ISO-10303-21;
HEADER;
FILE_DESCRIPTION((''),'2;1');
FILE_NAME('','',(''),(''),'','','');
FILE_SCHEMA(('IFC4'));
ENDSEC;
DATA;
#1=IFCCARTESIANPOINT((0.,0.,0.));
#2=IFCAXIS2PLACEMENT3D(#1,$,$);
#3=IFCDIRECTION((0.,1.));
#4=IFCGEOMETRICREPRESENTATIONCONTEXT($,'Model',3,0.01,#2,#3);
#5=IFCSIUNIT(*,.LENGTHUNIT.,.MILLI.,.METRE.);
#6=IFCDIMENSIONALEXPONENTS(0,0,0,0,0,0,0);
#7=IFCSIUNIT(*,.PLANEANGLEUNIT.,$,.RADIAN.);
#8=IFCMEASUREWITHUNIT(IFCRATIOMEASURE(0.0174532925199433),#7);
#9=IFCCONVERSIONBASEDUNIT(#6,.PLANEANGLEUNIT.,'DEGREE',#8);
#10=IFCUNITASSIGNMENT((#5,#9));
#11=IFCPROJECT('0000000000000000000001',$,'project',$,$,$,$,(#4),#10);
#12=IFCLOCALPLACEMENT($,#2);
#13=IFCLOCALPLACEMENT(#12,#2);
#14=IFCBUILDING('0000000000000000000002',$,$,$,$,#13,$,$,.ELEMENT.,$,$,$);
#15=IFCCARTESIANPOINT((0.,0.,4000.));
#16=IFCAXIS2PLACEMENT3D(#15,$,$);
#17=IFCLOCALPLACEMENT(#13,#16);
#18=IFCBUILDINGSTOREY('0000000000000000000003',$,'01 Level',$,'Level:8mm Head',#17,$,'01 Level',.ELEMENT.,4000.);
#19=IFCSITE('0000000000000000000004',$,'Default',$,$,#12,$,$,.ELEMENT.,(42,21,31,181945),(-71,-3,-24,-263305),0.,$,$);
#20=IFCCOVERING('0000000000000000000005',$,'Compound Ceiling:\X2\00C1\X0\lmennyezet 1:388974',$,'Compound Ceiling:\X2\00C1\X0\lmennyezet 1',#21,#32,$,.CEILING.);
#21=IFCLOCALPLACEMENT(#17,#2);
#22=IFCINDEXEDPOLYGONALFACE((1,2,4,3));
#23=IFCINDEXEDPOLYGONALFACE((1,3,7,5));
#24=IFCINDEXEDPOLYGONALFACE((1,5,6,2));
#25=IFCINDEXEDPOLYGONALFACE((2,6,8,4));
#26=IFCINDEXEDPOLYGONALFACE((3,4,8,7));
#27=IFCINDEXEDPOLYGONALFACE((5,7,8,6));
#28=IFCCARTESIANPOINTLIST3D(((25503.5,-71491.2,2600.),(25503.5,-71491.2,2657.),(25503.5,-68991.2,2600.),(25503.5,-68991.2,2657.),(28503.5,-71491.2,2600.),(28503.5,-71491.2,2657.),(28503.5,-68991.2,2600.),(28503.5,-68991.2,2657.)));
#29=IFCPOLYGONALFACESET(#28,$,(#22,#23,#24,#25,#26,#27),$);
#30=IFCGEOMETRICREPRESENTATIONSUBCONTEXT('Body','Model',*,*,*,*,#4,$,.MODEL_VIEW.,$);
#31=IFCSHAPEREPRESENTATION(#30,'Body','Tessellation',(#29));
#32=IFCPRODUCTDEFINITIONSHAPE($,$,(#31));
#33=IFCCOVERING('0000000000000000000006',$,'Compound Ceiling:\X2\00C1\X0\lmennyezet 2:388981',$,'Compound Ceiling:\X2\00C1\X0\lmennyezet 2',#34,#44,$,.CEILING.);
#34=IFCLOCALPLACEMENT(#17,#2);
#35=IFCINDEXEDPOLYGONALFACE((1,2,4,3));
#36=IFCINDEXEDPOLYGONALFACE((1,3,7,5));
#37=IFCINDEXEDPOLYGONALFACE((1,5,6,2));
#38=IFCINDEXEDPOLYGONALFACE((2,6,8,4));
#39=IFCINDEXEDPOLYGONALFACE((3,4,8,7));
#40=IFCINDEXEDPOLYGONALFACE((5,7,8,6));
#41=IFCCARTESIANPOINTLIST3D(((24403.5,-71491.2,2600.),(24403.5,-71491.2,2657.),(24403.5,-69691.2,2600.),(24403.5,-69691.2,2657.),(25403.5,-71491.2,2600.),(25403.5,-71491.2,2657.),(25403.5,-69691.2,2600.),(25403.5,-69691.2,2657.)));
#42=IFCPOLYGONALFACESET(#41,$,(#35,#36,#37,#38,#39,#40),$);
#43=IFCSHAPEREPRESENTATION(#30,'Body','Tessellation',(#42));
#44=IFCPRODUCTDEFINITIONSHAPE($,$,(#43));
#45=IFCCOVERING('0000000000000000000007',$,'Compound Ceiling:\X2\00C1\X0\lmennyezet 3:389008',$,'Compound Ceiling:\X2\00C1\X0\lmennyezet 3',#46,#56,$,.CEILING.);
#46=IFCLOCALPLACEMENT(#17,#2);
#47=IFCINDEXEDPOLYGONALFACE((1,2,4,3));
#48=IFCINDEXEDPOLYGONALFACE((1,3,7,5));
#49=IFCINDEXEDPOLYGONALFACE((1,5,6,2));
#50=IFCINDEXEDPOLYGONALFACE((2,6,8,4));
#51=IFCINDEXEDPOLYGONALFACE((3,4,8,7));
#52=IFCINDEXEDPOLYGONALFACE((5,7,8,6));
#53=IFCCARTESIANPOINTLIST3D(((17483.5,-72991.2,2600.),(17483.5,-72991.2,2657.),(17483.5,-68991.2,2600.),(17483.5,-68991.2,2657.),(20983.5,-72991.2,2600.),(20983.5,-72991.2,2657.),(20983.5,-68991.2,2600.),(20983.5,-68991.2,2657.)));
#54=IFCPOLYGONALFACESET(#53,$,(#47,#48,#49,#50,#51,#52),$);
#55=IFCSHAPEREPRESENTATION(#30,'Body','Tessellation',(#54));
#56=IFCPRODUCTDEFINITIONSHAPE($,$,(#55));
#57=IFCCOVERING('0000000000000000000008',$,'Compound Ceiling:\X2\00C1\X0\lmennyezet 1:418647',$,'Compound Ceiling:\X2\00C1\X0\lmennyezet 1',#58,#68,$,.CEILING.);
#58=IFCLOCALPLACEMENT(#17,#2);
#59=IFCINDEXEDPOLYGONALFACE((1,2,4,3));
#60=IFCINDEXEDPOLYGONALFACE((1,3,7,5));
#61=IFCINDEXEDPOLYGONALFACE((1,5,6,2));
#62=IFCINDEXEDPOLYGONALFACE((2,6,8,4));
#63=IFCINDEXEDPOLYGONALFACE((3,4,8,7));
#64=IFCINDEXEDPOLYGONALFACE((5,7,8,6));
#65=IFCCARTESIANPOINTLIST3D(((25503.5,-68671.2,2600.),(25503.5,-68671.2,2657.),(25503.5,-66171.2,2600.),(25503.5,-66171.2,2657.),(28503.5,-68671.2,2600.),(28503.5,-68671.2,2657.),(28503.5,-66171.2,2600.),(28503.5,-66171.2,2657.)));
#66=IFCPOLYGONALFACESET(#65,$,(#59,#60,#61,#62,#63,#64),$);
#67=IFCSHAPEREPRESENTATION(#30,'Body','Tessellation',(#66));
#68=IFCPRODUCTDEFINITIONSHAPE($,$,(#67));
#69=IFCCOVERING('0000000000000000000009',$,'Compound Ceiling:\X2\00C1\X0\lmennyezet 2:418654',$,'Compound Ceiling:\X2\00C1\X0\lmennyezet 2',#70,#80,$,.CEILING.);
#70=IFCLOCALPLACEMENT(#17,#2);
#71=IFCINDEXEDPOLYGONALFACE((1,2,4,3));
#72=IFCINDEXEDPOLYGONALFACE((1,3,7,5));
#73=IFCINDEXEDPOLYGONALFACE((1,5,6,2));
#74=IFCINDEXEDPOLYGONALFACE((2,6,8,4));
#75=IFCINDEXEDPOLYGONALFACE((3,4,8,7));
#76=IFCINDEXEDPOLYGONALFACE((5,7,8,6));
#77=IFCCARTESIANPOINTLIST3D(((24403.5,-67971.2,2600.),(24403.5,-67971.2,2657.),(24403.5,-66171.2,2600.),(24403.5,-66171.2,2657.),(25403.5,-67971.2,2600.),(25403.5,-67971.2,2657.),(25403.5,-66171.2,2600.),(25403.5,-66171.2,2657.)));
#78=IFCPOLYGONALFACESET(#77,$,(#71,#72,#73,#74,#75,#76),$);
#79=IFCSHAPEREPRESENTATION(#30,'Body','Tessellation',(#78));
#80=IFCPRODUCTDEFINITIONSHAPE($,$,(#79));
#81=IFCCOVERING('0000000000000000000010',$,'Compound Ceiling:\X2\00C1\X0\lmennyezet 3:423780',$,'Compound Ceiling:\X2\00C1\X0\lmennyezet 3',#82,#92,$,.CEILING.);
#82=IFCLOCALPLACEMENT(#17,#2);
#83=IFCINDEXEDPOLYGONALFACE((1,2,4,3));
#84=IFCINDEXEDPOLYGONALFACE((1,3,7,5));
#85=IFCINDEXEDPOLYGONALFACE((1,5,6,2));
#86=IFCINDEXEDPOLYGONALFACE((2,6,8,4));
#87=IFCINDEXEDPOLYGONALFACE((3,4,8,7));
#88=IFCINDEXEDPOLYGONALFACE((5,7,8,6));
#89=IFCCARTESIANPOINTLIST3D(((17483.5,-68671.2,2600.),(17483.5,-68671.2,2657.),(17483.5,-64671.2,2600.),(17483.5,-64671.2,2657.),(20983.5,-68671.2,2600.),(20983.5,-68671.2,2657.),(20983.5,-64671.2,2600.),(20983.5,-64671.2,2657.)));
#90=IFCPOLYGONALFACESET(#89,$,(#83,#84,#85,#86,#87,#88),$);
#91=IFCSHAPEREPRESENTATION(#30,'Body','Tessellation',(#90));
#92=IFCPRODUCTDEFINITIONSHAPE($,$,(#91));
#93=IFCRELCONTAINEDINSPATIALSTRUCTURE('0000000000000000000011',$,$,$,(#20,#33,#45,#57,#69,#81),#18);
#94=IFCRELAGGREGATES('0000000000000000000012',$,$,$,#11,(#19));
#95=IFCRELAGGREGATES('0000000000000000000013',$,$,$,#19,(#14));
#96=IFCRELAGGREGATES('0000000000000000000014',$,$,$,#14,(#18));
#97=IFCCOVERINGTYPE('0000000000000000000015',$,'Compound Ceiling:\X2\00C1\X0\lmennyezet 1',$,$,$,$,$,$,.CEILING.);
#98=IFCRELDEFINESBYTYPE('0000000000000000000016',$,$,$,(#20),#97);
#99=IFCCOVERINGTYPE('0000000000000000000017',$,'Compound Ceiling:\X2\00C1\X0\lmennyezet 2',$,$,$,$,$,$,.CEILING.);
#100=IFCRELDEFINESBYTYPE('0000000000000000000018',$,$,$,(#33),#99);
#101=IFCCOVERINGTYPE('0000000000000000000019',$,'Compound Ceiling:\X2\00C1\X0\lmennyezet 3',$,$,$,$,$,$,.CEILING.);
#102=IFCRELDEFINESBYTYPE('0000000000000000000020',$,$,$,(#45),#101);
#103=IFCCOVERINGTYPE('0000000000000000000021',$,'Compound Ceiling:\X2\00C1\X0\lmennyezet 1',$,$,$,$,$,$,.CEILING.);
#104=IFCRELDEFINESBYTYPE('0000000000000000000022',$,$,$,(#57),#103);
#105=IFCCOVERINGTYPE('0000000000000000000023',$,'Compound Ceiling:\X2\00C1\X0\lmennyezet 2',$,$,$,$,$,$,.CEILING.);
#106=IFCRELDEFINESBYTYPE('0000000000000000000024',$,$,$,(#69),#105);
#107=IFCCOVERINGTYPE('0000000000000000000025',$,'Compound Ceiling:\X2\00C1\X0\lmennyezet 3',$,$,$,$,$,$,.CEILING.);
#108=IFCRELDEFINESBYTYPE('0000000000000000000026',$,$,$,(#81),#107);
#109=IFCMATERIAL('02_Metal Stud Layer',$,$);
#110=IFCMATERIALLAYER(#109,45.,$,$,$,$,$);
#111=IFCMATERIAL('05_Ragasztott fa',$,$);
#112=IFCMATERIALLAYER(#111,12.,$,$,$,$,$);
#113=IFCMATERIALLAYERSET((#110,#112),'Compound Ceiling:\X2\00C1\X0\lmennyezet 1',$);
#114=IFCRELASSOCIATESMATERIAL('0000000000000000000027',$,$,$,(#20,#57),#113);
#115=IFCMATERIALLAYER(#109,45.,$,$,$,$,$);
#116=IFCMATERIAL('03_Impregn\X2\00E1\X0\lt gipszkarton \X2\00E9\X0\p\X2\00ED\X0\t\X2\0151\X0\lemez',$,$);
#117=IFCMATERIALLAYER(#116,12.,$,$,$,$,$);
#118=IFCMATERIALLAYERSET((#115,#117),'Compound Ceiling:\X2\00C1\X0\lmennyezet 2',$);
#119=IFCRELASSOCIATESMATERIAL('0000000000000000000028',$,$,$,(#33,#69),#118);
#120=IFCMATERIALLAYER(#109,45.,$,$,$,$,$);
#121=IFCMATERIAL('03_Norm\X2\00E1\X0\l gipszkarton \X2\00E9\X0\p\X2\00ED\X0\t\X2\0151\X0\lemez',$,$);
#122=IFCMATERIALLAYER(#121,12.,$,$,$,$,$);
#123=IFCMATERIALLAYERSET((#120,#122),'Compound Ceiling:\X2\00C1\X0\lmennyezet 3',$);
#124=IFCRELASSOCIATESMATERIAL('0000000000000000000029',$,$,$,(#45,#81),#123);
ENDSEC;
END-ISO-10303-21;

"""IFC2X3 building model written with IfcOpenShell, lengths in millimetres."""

from ifc_helpers import new_model, entity, si_unit, converted_unit, direction, frame, frame_2d, origin, origin_2d_with_axis, place, context, subcontext, project, spatial, rectangle, extrude, material, layer, layer_set, layer_usage, type_object, element, save


model = new_model("IFC2X3")

# Units and contexts
model_context = context("Model", 3, precision=0.01, world=origin(), true_north=direction((0.0, 1.0)))
body_context = subcontext(model_context, "Body", "Model", "MODEL_VIEW")
ifc_project = project(units=[si_unit("LENGTHUNIT", "METRE", prefix="MILLI"), converted_unit("PLANEANGLEUNIT", "DEGREE", entity("IfcRatioMeasure", 0.0174532925199433), si_unit("PLANEANGLEUNIT", "RADIAN"), dimensions=[0, 0, 0, 0, 0, 0, 0])], contexts=[model_context])

# Site, building, storey
site_placement = place(None, origin())
site = spatial("IfcSite", under=ifc_project, at=site_placement, Name="Default", CompositionType="ELEMENT", RefLatitude=(42, 21, 31, 181945), RefLongitude=(-71, -3, -24, -263305), RefElevation=0.0)
building_placement = place(site_placement, origin())
building = spatial("IfcBuilding", under=site, at=building_placement, CompositionType="ELEMENT")
storey_placement = place(building_placement, frame((0.0, 0.0, 4000.0)))
storey = spatial("IfcBuildingStorey", under=building, at=storey_placement, Name="01 Level", ObjectType="Level:8mm Head", LongName="01 Level", CompositionType="ELEMENT", Elevation=4000.0)

# Coverings
ifc_material_1 = material(Name="02_Metal Stud Layer")
ifc_layer_1 = layer(ifc_material_1, 45.0)
ifc_material_2 = material(Name="05_Ragasztott fa")
ifc_layer_2 = layer(ifc_material_2, 12.0)
ifc_layer_set_1 = layer_set([ifc_layer_1, ifc_layer_2], Name="Compound Ceiling:Álmennyezet 1")
ifc_layer_usage_1 = layer_usage(ifc_layer_set_1, "AXIS3", "POSITIVE", 0.0)
covering_type_1 = type_object("IfcCoveringType", Name="Compound Ceiling:Álmennyezet 1", PredefinedType="CEILING")
covering_1_placement = place(storey_placement, frame((25503.5, -71491.2, 2600.0)))
element("IfcCovering", 1, at=covering_1_placement, inside=storey, type_object=covering_type_1, material=ifc_layer_usage_1, Name="Compound Ceiling:Álmennyezet 1:388974", ObjectType="Compound Ceiling:Álmennyezet 1", PredefinedType="CEILING", context=body_context, shape_type="SweptSolid", body=[
    extrude(rectangle(XDim=3000.0, YDim=2500.0, at=frame_2d((0.0, 0.0), x_axis=(1.0, 0.0))), frame((1500.0, 1250.0, 0.0), z_axis=(0.0, 0.0, 1.0), x_axis=(-1.0, 0.0, 0.0)), (0.0, 0.0, 1.0), 57.0),
])
ifc_layer_3 = layer(ifc_material_1, 45.0)
ifc_material_3 = material(Name="03_Impregnált gipszkarton építőlemez")
ifc_layer_4 = layer(ifc_material_3, 12.0)
ifc_layer_set_2 = layer_set([ifc_layer_3, ifc_layer_4], Name="Compound Ceiling:Álmennyezet 2")
ifc_layer_usage_2 = layer_usage(ifc_layer_set_2, "AXIS3", "POSITIVE", 0.0)
covering_type_2 = type_object("IfcCoveringType", Name="Compound Ceiling:Álmennyezet 2", PredefinedType="CEILING")
covering_2_placement = place(storey_placement, frame((24403.5, -71491.2, 2600.0)))
element("IfcCovering", 2, at=covering_2_placement, inside=storey, type_object=covering_type_2, material=ifc_layer_usage_2, Name="Compound Ceiling:Álmennyezet 2:388981", ObjectType="Compound Ceiling:Álmennyezet 2", PredefinedType="CEILING", context=body_context, shape_type="SweptSolid", body=[
    extrude(rectangle(XDim=1000.0, YDim=1800.0, at=frame_2d((0.0, 0.0), x_axis=(1.0, 0.0))), frame((500.0, 900.0, 0.0), z_axis=(0.0, 0.0, 1.0), x_axis=(-1.0, 0.0, 0.0)), (0.0, 0.0, 1.0), 57.0),
])
ifc_layer_5 = layer(ifc_material_1, 45.0)
ifc_material_4 = material(Name="03_Normál gipszkarton építőlemez")
ifc_layer_6 = layer(ifc_material_4, 12.0)
ifc_layer_set_3 = layer_set([ifc_layer_5, ifc_layer_6], Name="Compound Ceiling:Álmennyezet 3")
ifc_layer_usage_3 = layer_usage(ifc_layer_set_3, "AXIS3", "POSITIVE", 0.0)
covering_type_3 = type_object("IfcCoveringType", Name="Compound Ceiling:Álmennyezet 3", PredefinedType="CEILING")
covering_3_placement = place(storey_placement, frame((17483.5, -72991.2, 2600.0)))
element("IfcCovering", 3, at=covering_3_placement, inside=storey, type_object=covering_type_3, material=ifc_layer_usage_3, Name="Compound Ceiling:Álmennyezet 3:389008", ObjectType="Compound Ceiling:Álmennyezet 3", PredefinedType="CEILING", context=body_context, shape_type="SweptSolid", body=[
    extrude(rectangle(XDim=4000.0, YDim=3500.0, at=frame_2d((0.0, 0.0), x_axis=(1.0, 0.0))), frame((1750.0, 2000.0, 0.0), z_axis=(0.0, 0.0, 1.0), x_axis=(0.0, 1.0, 0.0)), (0.0, 0.0, 1.0), 57.0),
])
ifc_layer_usage_4 = layer_usage(ifc_layer_set_1, "AXIS3", "POSITIVE", 0.0)
covering_type_4 = type_object("IfcCoveringType", Name="Compound Ceiling:Álmennyezet 1", PredefinedType="CEILING")
covering_4_placement = place(storey_placement, frame((25503.5, -68671.2, 2600.0)))
element("IfcCovering", 4, at=covering_4_placement, inside=storey, type_object=covering_type_4, material=ifc_layer_usage_4, Name="Compound Ceiling:Álmennyezet 1:418647", ObjectType="Compound Ceiling:Álmennyezet 1", PredefinedType="CEILING", context=body_context, shape_type="SweptSolid", body=[
    extrude(rectangle(XDim=2500.0, YDim=3000.0, at=frame_2d((0.0, 0.0), x_axis=(1.0, 0.0))), frame((1500.0, 1250.0, 0.0), z_axis=(0.0, 0.0, 1.0), x_axis=(0.0, 1.0, 0.0)), (0.0, 0.0, 1.0), 57.0),
])
ifc_layer_usage_5 = layer_usage(ifc_layer_set_2, "AXIS3", "POSITIVE", 0.0)
covering_type_5 = type_object("IfcCoveringType", Name="Compound Ceiling:Álmennyezet 2", PredefinedType="CEILING")
covering_5_placement = place(storey_placement, frame((24403.5, -67971.2, 2600.0)))
element("IfcCovering", 5, at=covering_5_placement, inside=storey, type_object=covering_type_5, material=ifc_layer_usage_5, Name="Compound Ceiling:Álmennyezet 2:418654", ObjectType="Compound Ceiling:Álmennyezet 2", PredefinedType="CEILING", context=body_context, shape_type="SweptSolid", body=[
    extrude(rectangle(XDim=1800.0, YDim=1000.0, at=origin_2d_with_axis()), frame((500.0, 900.0, 0.0), z_axis=(0.0, 0.0, 1.0), x_axis=(0.0, 1.0, 0.0)), (0.0, 0.0, 1.0), 57.0),
])
ifc_layer_usage_6 = layer_usage(ifc_layer_set_3, "AXIS3", "POSITIVE", 0.0)
covering_type_6 = type_object("IfcCoveringType", Name="Compound Ceiling:Álmennyezet 3", PredefinedType="CEILING")
covering_6_placement = place(storey_placement, frame((17483.5, -68671.2, 2600.0)))
element("IfcCovering", 6, at=covering_6_placement, inside=storey, type_object=covering_type_6, material=ifc_layer_usage_6, Name="Compound Ceiling:Álmennyezet 3:423780", ObjectType="Compound Ceiling:Álmennyezet 3", PredefinedType="CEILING", context=body_context, shape_type="SweptSolid", body=[
    extrude(rectangle(XDim=3500.0, YDim=4000.0, at=origin_2d_with_axis()), frame((1750.0, 2000.0, 0.0), z_axis=(0.0, 0.0, 1.0), x_axis=(-1.0, 0.0, 0.0)), (0.0, 0.0, 1.0), 57.0),
])

save(model, "model.ifc")
